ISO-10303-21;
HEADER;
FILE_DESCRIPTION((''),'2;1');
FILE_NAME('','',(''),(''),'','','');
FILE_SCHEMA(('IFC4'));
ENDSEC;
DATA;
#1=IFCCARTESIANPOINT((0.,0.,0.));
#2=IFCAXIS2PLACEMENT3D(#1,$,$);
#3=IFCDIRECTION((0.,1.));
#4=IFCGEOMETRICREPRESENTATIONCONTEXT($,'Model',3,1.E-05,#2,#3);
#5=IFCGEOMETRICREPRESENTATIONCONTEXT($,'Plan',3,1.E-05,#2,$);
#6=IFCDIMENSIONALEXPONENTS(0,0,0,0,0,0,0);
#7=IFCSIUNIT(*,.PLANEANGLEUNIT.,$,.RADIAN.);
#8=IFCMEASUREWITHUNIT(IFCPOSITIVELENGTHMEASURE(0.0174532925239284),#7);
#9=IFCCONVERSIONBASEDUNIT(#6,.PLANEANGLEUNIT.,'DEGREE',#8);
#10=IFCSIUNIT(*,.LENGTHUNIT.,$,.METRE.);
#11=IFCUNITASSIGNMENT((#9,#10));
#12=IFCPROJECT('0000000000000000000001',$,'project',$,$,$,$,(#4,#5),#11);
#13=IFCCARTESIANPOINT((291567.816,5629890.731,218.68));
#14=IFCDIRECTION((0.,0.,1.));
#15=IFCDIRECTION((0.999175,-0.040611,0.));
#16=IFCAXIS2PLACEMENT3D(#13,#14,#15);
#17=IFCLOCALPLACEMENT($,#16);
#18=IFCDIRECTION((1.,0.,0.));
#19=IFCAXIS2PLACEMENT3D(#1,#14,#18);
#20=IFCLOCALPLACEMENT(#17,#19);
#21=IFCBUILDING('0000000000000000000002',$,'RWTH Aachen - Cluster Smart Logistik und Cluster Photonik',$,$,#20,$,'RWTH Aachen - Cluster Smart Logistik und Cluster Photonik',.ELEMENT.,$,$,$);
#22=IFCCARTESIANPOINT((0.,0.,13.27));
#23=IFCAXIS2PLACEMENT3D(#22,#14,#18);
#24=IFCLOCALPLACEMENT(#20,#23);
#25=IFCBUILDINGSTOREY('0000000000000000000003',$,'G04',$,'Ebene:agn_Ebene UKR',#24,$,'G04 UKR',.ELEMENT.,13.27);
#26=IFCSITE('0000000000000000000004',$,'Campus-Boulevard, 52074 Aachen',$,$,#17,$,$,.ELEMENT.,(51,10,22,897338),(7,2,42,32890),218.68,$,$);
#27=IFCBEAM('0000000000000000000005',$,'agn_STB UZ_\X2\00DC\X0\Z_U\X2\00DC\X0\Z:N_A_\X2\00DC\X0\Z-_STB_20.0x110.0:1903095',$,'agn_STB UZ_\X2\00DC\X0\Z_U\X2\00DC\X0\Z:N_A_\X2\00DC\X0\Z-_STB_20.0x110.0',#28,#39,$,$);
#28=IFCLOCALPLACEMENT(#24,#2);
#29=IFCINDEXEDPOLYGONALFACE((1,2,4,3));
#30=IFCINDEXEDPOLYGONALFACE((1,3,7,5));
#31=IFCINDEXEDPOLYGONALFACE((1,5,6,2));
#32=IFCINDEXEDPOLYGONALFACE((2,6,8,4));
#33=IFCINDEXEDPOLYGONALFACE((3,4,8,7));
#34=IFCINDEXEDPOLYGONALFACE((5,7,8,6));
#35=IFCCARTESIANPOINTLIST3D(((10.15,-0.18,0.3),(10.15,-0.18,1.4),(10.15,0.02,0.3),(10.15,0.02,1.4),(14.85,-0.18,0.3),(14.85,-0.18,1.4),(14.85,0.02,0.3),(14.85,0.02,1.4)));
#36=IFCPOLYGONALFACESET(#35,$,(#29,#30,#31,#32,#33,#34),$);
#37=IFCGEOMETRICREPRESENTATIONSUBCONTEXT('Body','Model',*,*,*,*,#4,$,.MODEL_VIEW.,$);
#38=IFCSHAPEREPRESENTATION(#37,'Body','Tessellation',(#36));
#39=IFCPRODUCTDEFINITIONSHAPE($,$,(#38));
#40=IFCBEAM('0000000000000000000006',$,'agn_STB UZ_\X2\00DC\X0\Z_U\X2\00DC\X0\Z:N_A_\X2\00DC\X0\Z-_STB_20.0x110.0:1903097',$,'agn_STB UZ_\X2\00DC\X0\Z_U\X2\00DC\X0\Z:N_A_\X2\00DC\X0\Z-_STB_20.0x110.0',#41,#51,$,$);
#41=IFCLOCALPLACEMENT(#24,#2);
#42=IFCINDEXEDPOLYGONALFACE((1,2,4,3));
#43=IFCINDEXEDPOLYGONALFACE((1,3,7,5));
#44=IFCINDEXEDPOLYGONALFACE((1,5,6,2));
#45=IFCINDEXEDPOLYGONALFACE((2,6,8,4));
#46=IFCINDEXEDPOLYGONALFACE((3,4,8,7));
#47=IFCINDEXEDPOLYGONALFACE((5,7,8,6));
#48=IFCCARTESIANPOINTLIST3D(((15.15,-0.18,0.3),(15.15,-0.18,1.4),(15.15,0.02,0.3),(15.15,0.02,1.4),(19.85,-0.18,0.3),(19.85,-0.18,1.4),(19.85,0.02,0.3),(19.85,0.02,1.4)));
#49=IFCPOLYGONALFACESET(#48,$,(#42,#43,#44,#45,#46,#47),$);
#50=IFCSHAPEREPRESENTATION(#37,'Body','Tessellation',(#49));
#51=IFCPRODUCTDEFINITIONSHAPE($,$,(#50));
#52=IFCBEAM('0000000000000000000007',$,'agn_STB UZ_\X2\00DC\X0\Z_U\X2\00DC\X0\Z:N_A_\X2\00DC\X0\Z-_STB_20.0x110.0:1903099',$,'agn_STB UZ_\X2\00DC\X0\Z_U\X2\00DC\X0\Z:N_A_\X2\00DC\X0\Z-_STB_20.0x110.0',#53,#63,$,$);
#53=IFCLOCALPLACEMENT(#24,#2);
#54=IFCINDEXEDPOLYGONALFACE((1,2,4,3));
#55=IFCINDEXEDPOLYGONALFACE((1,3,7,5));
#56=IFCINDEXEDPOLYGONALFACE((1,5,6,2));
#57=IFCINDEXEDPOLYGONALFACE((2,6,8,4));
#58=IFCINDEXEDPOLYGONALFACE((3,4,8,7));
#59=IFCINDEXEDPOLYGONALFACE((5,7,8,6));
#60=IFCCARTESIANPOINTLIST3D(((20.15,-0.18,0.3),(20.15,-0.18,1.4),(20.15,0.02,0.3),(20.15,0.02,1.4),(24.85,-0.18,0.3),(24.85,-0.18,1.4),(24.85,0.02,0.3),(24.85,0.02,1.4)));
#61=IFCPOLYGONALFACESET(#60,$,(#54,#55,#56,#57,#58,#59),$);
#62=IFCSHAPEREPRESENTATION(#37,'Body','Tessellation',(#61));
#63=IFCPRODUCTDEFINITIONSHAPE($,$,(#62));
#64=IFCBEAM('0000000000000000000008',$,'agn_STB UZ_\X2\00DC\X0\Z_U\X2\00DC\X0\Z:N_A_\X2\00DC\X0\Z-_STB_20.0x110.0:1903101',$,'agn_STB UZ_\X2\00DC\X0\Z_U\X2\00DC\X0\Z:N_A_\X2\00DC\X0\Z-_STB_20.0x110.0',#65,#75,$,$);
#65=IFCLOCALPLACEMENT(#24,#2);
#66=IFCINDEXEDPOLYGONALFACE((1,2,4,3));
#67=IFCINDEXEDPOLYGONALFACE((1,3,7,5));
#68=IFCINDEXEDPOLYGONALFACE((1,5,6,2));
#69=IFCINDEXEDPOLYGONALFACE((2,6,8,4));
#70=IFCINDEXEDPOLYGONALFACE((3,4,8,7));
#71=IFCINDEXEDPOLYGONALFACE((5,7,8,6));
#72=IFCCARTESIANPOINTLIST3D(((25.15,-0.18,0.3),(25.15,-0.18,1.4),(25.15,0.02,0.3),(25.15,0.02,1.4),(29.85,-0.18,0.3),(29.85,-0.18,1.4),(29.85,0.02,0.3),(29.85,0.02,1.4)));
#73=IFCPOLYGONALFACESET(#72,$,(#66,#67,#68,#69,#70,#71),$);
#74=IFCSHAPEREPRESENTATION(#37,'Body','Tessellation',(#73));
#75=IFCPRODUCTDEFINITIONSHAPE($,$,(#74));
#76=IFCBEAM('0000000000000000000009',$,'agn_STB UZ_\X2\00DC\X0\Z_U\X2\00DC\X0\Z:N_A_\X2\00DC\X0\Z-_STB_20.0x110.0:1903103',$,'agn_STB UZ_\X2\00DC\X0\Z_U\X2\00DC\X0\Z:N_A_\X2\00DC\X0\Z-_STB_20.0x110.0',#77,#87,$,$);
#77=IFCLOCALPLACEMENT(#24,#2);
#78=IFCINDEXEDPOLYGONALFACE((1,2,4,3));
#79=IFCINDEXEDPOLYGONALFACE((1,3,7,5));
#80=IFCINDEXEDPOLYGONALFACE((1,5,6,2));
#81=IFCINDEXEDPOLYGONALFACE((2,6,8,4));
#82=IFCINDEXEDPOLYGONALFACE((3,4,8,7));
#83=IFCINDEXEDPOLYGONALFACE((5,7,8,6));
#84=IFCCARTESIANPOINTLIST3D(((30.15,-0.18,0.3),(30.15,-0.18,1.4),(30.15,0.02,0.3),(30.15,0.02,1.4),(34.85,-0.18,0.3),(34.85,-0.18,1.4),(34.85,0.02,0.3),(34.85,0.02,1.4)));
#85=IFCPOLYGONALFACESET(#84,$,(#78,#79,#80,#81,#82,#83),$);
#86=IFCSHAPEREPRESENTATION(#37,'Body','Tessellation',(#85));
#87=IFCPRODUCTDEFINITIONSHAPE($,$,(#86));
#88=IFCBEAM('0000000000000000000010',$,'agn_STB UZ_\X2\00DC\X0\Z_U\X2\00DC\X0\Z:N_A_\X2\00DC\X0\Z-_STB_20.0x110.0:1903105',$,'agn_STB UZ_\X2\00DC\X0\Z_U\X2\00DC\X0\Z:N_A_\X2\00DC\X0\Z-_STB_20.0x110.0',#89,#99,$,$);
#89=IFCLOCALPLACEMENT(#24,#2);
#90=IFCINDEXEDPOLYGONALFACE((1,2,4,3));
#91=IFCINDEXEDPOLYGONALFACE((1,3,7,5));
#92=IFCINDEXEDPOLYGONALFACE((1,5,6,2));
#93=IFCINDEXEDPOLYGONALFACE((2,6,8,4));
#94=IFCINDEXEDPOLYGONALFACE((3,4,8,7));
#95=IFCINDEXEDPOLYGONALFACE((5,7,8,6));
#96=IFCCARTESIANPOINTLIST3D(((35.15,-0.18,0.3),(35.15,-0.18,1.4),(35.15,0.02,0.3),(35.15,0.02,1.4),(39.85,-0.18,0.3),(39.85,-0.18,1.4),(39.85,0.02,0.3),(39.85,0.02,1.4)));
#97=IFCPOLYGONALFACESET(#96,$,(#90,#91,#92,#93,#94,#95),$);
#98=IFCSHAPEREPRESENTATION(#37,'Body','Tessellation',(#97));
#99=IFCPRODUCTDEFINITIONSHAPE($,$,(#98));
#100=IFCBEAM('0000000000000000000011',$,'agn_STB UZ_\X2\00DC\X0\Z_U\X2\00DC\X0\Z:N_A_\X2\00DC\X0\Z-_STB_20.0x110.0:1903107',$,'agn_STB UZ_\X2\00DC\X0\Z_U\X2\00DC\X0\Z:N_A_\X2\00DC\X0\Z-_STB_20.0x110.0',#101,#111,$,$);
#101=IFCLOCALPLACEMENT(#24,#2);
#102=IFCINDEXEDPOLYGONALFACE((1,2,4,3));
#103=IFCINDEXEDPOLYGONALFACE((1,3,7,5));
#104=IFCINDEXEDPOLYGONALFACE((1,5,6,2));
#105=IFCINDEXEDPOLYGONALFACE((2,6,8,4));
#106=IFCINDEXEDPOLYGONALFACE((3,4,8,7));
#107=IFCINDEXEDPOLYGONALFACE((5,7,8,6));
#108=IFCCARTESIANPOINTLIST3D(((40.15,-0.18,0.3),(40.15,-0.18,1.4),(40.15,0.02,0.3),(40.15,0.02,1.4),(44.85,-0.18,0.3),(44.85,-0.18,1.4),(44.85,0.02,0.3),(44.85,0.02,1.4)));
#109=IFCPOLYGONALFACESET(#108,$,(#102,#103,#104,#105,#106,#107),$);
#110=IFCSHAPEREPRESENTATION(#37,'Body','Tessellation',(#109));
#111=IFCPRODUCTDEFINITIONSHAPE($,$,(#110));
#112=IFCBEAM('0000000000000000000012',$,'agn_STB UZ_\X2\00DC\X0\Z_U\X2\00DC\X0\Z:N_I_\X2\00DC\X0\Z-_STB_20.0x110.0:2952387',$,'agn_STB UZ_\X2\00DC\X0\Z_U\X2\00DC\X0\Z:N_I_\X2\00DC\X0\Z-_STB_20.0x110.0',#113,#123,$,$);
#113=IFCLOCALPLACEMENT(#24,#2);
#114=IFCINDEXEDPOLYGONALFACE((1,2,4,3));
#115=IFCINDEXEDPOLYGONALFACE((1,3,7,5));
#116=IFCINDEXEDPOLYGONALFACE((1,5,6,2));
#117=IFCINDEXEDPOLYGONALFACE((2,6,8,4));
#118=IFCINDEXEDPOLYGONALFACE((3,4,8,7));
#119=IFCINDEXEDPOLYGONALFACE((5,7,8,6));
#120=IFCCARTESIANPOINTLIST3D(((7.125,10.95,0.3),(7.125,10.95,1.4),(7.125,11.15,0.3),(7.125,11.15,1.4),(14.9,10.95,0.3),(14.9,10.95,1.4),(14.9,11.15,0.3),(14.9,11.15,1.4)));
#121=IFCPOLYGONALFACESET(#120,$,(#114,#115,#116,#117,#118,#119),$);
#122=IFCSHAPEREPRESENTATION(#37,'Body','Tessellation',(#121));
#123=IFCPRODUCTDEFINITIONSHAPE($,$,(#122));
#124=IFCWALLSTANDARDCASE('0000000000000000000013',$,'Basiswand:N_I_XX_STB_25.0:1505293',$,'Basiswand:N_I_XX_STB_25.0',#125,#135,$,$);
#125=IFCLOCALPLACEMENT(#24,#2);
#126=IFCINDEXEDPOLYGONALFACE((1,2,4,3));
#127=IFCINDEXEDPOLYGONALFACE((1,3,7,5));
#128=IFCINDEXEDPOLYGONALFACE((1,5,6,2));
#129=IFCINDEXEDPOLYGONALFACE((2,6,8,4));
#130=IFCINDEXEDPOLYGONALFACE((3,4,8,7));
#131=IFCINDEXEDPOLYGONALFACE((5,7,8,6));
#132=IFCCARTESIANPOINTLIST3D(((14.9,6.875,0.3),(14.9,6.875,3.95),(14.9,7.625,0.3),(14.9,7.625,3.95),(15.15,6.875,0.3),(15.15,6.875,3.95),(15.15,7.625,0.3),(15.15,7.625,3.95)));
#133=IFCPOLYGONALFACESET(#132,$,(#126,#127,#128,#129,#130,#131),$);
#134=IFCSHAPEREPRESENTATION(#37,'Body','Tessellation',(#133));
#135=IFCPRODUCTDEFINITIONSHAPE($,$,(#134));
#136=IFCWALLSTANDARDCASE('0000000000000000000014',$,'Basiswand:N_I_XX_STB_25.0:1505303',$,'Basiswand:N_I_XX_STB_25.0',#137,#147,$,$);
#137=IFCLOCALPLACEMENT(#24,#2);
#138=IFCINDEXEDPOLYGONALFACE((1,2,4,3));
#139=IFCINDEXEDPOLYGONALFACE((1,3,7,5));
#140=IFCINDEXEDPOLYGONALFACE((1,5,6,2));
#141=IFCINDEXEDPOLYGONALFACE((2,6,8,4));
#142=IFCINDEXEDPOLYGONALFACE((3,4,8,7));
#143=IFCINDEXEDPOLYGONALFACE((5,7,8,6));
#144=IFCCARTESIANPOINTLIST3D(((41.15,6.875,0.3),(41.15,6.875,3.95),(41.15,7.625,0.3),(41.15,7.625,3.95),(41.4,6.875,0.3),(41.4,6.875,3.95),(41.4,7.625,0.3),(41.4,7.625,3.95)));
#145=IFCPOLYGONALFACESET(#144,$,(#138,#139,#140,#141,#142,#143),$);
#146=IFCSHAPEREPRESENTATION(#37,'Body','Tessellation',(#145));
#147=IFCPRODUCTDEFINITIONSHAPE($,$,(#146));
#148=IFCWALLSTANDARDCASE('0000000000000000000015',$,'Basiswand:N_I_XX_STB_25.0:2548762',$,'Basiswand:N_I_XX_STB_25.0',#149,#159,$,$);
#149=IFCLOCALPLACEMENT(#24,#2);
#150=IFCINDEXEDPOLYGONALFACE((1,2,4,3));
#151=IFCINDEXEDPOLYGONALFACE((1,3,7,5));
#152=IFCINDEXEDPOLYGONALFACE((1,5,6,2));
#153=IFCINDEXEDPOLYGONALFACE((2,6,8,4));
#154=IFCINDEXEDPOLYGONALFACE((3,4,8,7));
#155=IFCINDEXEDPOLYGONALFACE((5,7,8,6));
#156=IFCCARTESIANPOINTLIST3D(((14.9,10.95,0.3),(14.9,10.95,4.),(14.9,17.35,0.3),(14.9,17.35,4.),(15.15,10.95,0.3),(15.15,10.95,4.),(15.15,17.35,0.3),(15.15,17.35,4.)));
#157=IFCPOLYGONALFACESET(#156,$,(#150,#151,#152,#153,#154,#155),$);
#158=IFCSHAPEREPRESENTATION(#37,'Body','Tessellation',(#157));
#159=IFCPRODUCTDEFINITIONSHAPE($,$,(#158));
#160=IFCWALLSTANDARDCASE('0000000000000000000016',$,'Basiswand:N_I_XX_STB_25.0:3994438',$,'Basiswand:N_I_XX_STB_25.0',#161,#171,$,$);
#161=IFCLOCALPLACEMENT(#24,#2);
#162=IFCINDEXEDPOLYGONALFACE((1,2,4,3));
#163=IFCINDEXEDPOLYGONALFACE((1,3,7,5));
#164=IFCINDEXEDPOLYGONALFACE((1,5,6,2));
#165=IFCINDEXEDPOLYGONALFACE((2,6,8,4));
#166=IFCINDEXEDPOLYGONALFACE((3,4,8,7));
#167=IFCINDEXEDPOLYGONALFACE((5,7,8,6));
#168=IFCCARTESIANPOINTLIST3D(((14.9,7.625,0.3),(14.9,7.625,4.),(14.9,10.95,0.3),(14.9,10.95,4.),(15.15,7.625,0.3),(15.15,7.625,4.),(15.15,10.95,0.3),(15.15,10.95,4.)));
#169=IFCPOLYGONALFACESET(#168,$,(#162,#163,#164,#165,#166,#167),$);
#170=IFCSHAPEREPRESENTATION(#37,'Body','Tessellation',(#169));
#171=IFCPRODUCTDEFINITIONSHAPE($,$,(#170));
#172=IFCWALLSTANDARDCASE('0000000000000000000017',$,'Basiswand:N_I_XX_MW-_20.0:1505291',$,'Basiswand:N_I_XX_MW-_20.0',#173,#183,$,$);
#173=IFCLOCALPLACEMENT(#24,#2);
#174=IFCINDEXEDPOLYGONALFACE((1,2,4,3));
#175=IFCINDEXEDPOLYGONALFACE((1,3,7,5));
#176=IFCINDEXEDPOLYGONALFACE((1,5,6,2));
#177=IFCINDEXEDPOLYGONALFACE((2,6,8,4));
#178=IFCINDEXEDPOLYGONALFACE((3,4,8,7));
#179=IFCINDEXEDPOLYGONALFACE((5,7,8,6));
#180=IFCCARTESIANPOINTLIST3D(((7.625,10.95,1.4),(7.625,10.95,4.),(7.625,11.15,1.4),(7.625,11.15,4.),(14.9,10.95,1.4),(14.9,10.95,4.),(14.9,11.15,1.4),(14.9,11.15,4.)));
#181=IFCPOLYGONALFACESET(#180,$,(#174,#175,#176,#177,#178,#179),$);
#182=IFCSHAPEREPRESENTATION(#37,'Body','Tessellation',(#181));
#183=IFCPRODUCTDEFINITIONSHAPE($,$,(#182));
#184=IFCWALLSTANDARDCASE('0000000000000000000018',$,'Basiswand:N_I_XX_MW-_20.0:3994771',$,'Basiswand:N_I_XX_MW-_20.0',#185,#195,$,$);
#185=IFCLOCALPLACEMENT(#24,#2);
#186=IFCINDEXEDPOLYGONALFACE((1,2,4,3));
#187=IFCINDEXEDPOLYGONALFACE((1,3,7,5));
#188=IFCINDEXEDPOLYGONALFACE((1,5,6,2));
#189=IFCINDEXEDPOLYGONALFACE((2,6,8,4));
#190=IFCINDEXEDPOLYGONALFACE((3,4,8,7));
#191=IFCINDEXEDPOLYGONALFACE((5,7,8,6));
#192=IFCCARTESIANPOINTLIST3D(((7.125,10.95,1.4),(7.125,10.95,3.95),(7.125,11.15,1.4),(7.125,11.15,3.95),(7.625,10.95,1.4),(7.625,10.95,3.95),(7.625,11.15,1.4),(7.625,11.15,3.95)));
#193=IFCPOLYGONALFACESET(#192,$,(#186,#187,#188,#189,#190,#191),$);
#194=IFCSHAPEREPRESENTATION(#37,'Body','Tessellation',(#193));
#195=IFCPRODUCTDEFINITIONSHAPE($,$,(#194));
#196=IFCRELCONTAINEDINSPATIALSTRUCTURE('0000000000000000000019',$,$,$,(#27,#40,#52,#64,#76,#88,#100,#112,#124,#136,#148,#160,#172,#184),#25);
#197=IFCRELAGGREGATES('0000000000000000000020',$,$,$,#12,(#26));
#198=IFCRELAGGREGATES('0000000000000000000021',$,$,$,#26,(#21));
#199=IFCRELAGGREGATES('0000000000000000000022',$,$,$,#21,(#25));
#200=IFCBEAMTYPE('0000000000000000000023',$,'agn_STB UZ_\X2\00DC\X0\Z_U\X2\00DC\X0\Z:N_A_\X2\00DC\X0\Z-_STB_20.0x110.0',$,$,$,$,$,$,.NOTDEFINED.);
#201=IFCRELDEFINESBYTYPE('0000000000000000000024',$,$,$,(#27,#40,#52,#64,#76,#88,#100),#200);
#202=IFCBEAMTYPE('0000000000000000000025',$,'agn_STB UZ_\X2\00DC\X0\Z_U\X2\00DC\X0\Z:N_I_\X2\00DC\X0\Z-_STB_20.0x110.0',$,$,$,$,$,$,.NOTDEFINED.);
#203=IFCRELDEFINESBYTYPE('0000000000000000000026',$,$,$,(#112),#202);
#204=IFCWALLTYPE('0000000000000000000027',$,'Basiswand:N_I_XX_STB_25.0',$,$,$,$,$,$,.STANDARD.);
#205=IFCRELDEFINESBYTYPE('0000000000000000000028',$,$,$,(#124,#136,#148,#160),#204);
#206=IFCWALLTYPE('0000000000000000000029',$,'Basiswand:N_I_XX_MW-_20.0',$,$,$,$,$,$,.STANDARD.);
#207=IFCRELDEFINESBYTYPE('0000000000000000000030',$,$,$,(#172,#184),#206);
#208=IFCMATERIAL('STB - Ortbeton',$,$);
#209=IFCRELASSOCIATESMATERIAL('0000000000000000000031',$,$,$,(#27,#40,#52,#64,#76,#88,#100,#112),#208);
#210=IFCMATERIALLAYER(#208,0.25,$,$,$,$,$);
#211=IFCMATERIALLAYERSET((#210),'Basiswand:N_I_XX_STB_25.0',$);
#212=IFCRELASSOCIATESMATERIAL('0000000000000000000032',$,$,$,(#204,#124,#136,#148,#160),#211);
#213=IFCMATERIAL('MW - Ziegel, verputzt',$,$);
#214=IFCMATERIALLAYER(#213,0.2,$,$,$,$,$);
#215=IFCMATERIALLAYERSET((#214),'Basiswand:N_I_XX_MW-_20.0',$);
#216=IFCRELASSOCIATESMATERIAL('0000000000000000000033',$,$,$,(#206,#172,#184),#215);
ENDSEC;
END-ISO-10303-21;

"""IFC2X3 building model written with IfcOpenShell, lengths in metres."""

from ifc_helpers import new_model, entity, si_unit, converted_unit, direction, frame, frame_2d, origin, origin_with_axes, place, context, subcontext, project, spatial, rectangle, extrude, material, layer, layer_set, layer_usage, type_object, element, save


model = new_model("IFC2X3")

# Units and contexts
model_context = context("Model", 3, precision=1e-05, world=origin(), true_north=direction((0.0, 1.0)))
plan_context = context("Plan", 3, precision=1e-05, world=origin())
body_context = subcontext(model_context, "Body", "Model", "MODEL_VIEW")
ifc_project = project(units=[converted_unit("PLANEANGLEUNIT", "DEGREE", entity("IfcPositiveLengthMeasure", 0.0174532925239284), si_unit("PLANEANGLEUNIT", "RADIAN"), dimensions=[0, 0, 0, 0, 0, 0, 0]), si_unit("LENGTHUNIT", "METRE")], contexts=[model_context, plan_context])

# Site, building, storey
site_placement = place(None, frame((291567.816, 5629890.731, 218.68), z_axis=(0.0, 0.0, 1.0), x_axis=(0.999175, -0.040611, 0.0)))
site = spatial("IfcSite", under=ifc_project, at=site_placement, Name="Campus-Boulevard, 52074 Aachen", CompositionType="ELEMENT", RefLatitude=(51, 10, 22, 897338), RefLongitude=(7, 2, 42, 32890), RefElevation=218.68)
building_placement = place(site_placement, origin_with_axes())
building = spatial("IfcBuilding", under=site, at=building_placement, Name="RWTH Aachen - Cluster Smart Logistik und Cluster Photonik", LongName="RWTH Aachen - Cluster Smart Logistik und Cluster Photonik", CompositionType="ELEMENT")
storey_placement = place(building_placement, frame((0.0, 0.0, 13.27), z_axis=(0.0, 0.0, 1.0), x_axis=(1.0, 0.0, 0.0)))
storey = spatial("IfcBuildingStorey", under=building, at=storey_placement, Name="G04", ObjectType="Ebene:agn_Ebene UKR", LongName="G04 UKR", CompositionType="ELEMENT", Elevation=13.27)

# Beams
ifc_material_1 = material(Name="STB - Ortbeton")
beam_type_1 = type_object("IfcBeamType", Name="agn_STB UZ_ÜZ_UÜZ:N_A_ÜZ-_STB_20.0x110.0", PredefinedType="NOTDEFINED")
for number, where, z_axis, x_axis, name in (
    (1, (10.15, -0.08, 0.3), (0.0, 0.0, 1.0), (1.0, 0.0, 0.0), "agn_STB UZ_ÜZ_UÜZ:N_A_ÜZ-_STB_20.0x110.0:1903095"),
    (2, (15.15, -0.08, 0.3), (0.0, 0.0, 1.0), (1.0, 0.0, 0.0), "agn_STB UZ_ÜZ_UÜZ:N_A_ÜZ-_STB_20.0x110.0:1903097"),
    (3, (20.15, -0.08, 0.3), (0.0, 0.0, 1.0), (1.0, 0.0, 0.0), "agn_STB UZ_ÜZ_UÜZ:N_A_ÜZ-_STB_20.0x110.0:1903099"),
    (4, (25.15, -0.08, 0.3), (0.0, 0.0, 1.0), (1.0, 0.0, 0.0), "agn_STB UZ_ÜZ_UÜZ:N_A_ÜZ-_STB_20.0x110.0:1903101"),
    (5, (30.15, -0.08, 0.3), (0.0, 0.0, 1.0), (1.0, 0.0, 0.0), "agn_STB UZ_ÜZ_UÜZ:N_A_ÜZ-_STB_20.0x110.0:1903103"),
    (6, (35.15, -0.08, 0.3), (0.0, 0.0, 1.0), (1.0, 0.0, 0.0), "agn_STB UZ_ÜZ_UÜZ:N_A_ÜZ-_STB_20.0x110.0:1903105"),
    (7, (40.15, -0.08, 0.3), (0.0, 0.0, 1.0), (1.0, 0.0, 0.0), "agn_STB UZ_ÜZ_UÜZ:N_A_ÜZ-_STB_20.0x110.0:1903107"),
):
    element("IfcBeam", number, at=place(storey_placement, frame(where, z_axis=z_axis, x_axis=x_axis)), inside=storey, type_object=beam_type_1, material=ifc_material_1, Name=name, ObjectType="agn_STB UZ_ÜZ_UÜZ:N_A_ÜZ-_STB_20.0x110.0", context=body_context, shape_type="SweptSolid", body=[
        extrude(rectangle(XDim=1.1, YDim=0.2, at=frame_2d((0.0, 0.0), x_axis=(1.0, 0.0))), frame((0.0, 0.0, 0.55), z_axis=(1.0, 0.0, 0.0), x_axis=(0.0, 0.0, -1.0)), (0.0, 0.0, 1.0), 4.7),
    ])
beam_type_2 = type_object("IfcBeamType", Name="agn_STB UZ_ÜZ_UÜZ:N_I_ÜZ-_STB_20.0x110.0", PredefinedType="NOTDEFINED")
beam_1_placement = place(storey_placement, frame((15.025, 11.05, 0.3), z_axis=(0.0, 0.0, 1.0), x_axis=(-1.0, 0.0, 0.0)))
element("IfcBeam", 8, at=beam_1_placement, inside=storey, type_object=beam_type_2, material=ifc_material_1, Name="agn_STB UZ_ÜZ_UÜZ:N_I_ÜZ-_STB_20.0x110.0:2952387", ObjectType="agn_STB UZ_ÜZ_UÜZ:N_I_ÜZ-_STB_20.0x110.0", context=body_context, shape_type="SweptSolid", body=[
    extrude(rectangle(XDim=1.1, YDim=0.2, at=frame_2d((0.0, 0.0), x_axis=(1.0, 0.0))), frame((0.125, 0.0, 0.55), z_axis=(1.0, 0.0, 0.0), x_axis=(0.0, 0.0, -1.0)), (0.0, 0.0, 1.0), 7.775),
])

# Walls
ifc_layer_1 = layer(ifc_material_1, 0.25)
ifc_layer_set_1 = layer_set([ifc_layer_1], Name="Basiswand:N_I_XX_STB_25.0")
ifc_layer_usage_1 = layer_usage(ifc_layer_set_1, "AXIS2", "NEGATIVE", 0.125)
wall_type_1 = type_object("IfcWallType", Name="Basiswand:N_I_XX_STB_25.0", PredefinedType="STANDARD", material=ifc_layer_set_1)
wall_1_placement = place(storey_placement, frame((15.025, 6.875, 0.3), z_axis=(0.0, 0.0, 1.0), x_axis=(0.0, 1.0, 0.0)))
element("IfcWallStandardCase", 9, at=wall_1_placement, inside=storey, type_object=wall_type_1, material=ifc_layer_usage_1, Name="Basiswand:N_I_XX_STB_25.0:1505293", ObjectType="Basiswand:N_I_XX_STB_25.0", context=body_context, shape_type="SweptSolid", body=[
    extrude(rectangle(XDim=0.75, YDim=0.25, at=frame_2d((0.375, 0.0), x_axis=(-1.0, 0.0))), origin(), (0.0, 0.0, 1.0), 3.65),
])
ifc_layer_usage_2 = layer_usage(ifc_layer_set_1, "AXIS2", "NEGATIVE", 0.125)
wall_2_placement = place(storey_placement, frame((41.275, 6.875, 0.3), z_axis=(0.0, 0.0, 1.0), x_axis=(0.0, 1.0, 0.0)))
element("IfcWallStandardCase", 10, at=wall_2_placement, inside=storey, type_object=wall_type_1, material=ifc_layer_usage_2, Name="Basiswand:N_I_XX_STB_25.0:1505303", ObjectType="Basiswand:N_I_XX_STB_25.0", context=body_context, shape_type="SweptSolid", body=[
    extrude(rectangle(XDim=0.75, YDim=0.25, at=frame_2d((0.375, 0.0), x_axis=(-1.0, 0.0))), origin(), (0.0, 0.0, 1.0), 3.65),
])
ifc_layer_usage_3 = layer_usage(ifc_layer_set_1, "AXIS2", "NEGATIVE", 0.125)
wall_3_placement = place(storey_placement, frame((15.025, 10.95, 0.3), z_axis=(0.0, 0.0, 1.0), x_axis=(0.0, 1.0, 0.0)))
element("IfcWallStandardCase", 11, at=wall_3_placement, inside=storey, type_object=wall_type_1, material=ifc_layer_usage_3, Name="Basiswand:N_I_XX_STB_25.0:2548762", ObjectType="Basiswand:N_I_XX_STB_25.0", context=body_context, shape_type="SweptSolid", body=[
    extrude(rectangle(XDim=6.4, YDim=0.25, at=frame_2d((3.2, 0.0), x_axis=(-1.0, 0.0))), origin(), (0.0, 0.0, 1.0), 3.7),
])
ifc_layer_usage_4 = layer_usage(ifc_layer_set_1, "AXIS2", "NEGATIVE", 0.125)
wall_4_placement = place(storey_placement, frame((15.025, 7.625, 0.3), z_axis=(0.0, 0.0, 1.0), x_axis=(0.0, 1.0, 0.0)))
element("IfcWallStandardCase", 12, at=wall_4_placement, inside=storey, type_object=wall_type_1, material=ifc_layer_usage_4, Name="Basiswand:N_I_XX_STB_25.0:3994438", ObjectType="Basiswand:N_I_XX_STB_25.0", context=body_context, shape_type="SweptSolid", body=[
    extrude(rectangle(XDim=3.325, YDim=0.25, at=frame_2d((1.6625, 0.0), x_axis=(-1.0, 0.0))), origin(), (0.0, 0.0, 1.0), 3.7),
])
ifc_material_2 = material(Name="MW - Ziegel, verputzt")
ifc_layer_2 = layer(ifc_material_2, 0.2)
ifc_layer_set_2 = layer_set([ifc_layer_2], Name="Basiswand:N_I_XX_MW-_20.0")
ifc_layer_usage_5 = layer_usage(ifc_layer_set_2, "AXIS2", "NEGATIVE", 0.1)
wall_type_2 = type_object("IfcWallType", Name="Basiswand:N_I_XX_MW-_20.0", PredefinedType="STANDARD", material=ifc_layer_set_2)
wall_5_placement = place(storey_placement, frame((14.9, 11.05, 1.4), z_axis=(0.0, 0.0, 1.0), x_axis=(-1.0, 0.0, 0.0)))
element("IfcWallStandardCase", 13, at=wall_5_placement, inside=storey, type_object=wall_type_2, material=ifc_layer_usage_5, Name="Basiswand:N_I_XX_MW-_20.0:1505291", ObjectType="Basiswand:N_I_XX_MW-_20.0", context=body_context, shape_type="SweptSolid", body=[
    extrude(rectangle(XDim=7.275, YDim=0.2, at=frame_2d((3.6375, 0.0), x_axis=(-1.0, 0.0))), origin(), (0.0, 0.0, 1.0), 2.6),
])
ifc_layer_usage_6 = layer_usage(ifc_layer_set_2, "AXIS2", "NEGATIVE", 0.1)
wall_6_placement = place(storey_placement, frame((7.625, 11.05, 1.4), z_axis=(0.0, 0.0, 1.0), x_axis=(-1.0, 0.0, 0.0)))
element("IfcWallStandardCase", 14, at=wall_6_placement, inside=storey, type_object=wall_type_2, material=ifc_layer_usage_6, Name="Basiswand:N_I_XX_MW-_20.0:3994771", ObjectType="Basiswand:N_I_XX_MW-_20.0", context=body_context, shape_type="SweptSolid", body=[
    extrude(rectangle(XDim=0.5, YDim=0.2, at=frame_2d((0.25, 0.0), x_axis=(-1.0, 0.0))), origin(), (0.0, 0.0, 1.0), 2.55),
])

save(model, "model.ifc")
